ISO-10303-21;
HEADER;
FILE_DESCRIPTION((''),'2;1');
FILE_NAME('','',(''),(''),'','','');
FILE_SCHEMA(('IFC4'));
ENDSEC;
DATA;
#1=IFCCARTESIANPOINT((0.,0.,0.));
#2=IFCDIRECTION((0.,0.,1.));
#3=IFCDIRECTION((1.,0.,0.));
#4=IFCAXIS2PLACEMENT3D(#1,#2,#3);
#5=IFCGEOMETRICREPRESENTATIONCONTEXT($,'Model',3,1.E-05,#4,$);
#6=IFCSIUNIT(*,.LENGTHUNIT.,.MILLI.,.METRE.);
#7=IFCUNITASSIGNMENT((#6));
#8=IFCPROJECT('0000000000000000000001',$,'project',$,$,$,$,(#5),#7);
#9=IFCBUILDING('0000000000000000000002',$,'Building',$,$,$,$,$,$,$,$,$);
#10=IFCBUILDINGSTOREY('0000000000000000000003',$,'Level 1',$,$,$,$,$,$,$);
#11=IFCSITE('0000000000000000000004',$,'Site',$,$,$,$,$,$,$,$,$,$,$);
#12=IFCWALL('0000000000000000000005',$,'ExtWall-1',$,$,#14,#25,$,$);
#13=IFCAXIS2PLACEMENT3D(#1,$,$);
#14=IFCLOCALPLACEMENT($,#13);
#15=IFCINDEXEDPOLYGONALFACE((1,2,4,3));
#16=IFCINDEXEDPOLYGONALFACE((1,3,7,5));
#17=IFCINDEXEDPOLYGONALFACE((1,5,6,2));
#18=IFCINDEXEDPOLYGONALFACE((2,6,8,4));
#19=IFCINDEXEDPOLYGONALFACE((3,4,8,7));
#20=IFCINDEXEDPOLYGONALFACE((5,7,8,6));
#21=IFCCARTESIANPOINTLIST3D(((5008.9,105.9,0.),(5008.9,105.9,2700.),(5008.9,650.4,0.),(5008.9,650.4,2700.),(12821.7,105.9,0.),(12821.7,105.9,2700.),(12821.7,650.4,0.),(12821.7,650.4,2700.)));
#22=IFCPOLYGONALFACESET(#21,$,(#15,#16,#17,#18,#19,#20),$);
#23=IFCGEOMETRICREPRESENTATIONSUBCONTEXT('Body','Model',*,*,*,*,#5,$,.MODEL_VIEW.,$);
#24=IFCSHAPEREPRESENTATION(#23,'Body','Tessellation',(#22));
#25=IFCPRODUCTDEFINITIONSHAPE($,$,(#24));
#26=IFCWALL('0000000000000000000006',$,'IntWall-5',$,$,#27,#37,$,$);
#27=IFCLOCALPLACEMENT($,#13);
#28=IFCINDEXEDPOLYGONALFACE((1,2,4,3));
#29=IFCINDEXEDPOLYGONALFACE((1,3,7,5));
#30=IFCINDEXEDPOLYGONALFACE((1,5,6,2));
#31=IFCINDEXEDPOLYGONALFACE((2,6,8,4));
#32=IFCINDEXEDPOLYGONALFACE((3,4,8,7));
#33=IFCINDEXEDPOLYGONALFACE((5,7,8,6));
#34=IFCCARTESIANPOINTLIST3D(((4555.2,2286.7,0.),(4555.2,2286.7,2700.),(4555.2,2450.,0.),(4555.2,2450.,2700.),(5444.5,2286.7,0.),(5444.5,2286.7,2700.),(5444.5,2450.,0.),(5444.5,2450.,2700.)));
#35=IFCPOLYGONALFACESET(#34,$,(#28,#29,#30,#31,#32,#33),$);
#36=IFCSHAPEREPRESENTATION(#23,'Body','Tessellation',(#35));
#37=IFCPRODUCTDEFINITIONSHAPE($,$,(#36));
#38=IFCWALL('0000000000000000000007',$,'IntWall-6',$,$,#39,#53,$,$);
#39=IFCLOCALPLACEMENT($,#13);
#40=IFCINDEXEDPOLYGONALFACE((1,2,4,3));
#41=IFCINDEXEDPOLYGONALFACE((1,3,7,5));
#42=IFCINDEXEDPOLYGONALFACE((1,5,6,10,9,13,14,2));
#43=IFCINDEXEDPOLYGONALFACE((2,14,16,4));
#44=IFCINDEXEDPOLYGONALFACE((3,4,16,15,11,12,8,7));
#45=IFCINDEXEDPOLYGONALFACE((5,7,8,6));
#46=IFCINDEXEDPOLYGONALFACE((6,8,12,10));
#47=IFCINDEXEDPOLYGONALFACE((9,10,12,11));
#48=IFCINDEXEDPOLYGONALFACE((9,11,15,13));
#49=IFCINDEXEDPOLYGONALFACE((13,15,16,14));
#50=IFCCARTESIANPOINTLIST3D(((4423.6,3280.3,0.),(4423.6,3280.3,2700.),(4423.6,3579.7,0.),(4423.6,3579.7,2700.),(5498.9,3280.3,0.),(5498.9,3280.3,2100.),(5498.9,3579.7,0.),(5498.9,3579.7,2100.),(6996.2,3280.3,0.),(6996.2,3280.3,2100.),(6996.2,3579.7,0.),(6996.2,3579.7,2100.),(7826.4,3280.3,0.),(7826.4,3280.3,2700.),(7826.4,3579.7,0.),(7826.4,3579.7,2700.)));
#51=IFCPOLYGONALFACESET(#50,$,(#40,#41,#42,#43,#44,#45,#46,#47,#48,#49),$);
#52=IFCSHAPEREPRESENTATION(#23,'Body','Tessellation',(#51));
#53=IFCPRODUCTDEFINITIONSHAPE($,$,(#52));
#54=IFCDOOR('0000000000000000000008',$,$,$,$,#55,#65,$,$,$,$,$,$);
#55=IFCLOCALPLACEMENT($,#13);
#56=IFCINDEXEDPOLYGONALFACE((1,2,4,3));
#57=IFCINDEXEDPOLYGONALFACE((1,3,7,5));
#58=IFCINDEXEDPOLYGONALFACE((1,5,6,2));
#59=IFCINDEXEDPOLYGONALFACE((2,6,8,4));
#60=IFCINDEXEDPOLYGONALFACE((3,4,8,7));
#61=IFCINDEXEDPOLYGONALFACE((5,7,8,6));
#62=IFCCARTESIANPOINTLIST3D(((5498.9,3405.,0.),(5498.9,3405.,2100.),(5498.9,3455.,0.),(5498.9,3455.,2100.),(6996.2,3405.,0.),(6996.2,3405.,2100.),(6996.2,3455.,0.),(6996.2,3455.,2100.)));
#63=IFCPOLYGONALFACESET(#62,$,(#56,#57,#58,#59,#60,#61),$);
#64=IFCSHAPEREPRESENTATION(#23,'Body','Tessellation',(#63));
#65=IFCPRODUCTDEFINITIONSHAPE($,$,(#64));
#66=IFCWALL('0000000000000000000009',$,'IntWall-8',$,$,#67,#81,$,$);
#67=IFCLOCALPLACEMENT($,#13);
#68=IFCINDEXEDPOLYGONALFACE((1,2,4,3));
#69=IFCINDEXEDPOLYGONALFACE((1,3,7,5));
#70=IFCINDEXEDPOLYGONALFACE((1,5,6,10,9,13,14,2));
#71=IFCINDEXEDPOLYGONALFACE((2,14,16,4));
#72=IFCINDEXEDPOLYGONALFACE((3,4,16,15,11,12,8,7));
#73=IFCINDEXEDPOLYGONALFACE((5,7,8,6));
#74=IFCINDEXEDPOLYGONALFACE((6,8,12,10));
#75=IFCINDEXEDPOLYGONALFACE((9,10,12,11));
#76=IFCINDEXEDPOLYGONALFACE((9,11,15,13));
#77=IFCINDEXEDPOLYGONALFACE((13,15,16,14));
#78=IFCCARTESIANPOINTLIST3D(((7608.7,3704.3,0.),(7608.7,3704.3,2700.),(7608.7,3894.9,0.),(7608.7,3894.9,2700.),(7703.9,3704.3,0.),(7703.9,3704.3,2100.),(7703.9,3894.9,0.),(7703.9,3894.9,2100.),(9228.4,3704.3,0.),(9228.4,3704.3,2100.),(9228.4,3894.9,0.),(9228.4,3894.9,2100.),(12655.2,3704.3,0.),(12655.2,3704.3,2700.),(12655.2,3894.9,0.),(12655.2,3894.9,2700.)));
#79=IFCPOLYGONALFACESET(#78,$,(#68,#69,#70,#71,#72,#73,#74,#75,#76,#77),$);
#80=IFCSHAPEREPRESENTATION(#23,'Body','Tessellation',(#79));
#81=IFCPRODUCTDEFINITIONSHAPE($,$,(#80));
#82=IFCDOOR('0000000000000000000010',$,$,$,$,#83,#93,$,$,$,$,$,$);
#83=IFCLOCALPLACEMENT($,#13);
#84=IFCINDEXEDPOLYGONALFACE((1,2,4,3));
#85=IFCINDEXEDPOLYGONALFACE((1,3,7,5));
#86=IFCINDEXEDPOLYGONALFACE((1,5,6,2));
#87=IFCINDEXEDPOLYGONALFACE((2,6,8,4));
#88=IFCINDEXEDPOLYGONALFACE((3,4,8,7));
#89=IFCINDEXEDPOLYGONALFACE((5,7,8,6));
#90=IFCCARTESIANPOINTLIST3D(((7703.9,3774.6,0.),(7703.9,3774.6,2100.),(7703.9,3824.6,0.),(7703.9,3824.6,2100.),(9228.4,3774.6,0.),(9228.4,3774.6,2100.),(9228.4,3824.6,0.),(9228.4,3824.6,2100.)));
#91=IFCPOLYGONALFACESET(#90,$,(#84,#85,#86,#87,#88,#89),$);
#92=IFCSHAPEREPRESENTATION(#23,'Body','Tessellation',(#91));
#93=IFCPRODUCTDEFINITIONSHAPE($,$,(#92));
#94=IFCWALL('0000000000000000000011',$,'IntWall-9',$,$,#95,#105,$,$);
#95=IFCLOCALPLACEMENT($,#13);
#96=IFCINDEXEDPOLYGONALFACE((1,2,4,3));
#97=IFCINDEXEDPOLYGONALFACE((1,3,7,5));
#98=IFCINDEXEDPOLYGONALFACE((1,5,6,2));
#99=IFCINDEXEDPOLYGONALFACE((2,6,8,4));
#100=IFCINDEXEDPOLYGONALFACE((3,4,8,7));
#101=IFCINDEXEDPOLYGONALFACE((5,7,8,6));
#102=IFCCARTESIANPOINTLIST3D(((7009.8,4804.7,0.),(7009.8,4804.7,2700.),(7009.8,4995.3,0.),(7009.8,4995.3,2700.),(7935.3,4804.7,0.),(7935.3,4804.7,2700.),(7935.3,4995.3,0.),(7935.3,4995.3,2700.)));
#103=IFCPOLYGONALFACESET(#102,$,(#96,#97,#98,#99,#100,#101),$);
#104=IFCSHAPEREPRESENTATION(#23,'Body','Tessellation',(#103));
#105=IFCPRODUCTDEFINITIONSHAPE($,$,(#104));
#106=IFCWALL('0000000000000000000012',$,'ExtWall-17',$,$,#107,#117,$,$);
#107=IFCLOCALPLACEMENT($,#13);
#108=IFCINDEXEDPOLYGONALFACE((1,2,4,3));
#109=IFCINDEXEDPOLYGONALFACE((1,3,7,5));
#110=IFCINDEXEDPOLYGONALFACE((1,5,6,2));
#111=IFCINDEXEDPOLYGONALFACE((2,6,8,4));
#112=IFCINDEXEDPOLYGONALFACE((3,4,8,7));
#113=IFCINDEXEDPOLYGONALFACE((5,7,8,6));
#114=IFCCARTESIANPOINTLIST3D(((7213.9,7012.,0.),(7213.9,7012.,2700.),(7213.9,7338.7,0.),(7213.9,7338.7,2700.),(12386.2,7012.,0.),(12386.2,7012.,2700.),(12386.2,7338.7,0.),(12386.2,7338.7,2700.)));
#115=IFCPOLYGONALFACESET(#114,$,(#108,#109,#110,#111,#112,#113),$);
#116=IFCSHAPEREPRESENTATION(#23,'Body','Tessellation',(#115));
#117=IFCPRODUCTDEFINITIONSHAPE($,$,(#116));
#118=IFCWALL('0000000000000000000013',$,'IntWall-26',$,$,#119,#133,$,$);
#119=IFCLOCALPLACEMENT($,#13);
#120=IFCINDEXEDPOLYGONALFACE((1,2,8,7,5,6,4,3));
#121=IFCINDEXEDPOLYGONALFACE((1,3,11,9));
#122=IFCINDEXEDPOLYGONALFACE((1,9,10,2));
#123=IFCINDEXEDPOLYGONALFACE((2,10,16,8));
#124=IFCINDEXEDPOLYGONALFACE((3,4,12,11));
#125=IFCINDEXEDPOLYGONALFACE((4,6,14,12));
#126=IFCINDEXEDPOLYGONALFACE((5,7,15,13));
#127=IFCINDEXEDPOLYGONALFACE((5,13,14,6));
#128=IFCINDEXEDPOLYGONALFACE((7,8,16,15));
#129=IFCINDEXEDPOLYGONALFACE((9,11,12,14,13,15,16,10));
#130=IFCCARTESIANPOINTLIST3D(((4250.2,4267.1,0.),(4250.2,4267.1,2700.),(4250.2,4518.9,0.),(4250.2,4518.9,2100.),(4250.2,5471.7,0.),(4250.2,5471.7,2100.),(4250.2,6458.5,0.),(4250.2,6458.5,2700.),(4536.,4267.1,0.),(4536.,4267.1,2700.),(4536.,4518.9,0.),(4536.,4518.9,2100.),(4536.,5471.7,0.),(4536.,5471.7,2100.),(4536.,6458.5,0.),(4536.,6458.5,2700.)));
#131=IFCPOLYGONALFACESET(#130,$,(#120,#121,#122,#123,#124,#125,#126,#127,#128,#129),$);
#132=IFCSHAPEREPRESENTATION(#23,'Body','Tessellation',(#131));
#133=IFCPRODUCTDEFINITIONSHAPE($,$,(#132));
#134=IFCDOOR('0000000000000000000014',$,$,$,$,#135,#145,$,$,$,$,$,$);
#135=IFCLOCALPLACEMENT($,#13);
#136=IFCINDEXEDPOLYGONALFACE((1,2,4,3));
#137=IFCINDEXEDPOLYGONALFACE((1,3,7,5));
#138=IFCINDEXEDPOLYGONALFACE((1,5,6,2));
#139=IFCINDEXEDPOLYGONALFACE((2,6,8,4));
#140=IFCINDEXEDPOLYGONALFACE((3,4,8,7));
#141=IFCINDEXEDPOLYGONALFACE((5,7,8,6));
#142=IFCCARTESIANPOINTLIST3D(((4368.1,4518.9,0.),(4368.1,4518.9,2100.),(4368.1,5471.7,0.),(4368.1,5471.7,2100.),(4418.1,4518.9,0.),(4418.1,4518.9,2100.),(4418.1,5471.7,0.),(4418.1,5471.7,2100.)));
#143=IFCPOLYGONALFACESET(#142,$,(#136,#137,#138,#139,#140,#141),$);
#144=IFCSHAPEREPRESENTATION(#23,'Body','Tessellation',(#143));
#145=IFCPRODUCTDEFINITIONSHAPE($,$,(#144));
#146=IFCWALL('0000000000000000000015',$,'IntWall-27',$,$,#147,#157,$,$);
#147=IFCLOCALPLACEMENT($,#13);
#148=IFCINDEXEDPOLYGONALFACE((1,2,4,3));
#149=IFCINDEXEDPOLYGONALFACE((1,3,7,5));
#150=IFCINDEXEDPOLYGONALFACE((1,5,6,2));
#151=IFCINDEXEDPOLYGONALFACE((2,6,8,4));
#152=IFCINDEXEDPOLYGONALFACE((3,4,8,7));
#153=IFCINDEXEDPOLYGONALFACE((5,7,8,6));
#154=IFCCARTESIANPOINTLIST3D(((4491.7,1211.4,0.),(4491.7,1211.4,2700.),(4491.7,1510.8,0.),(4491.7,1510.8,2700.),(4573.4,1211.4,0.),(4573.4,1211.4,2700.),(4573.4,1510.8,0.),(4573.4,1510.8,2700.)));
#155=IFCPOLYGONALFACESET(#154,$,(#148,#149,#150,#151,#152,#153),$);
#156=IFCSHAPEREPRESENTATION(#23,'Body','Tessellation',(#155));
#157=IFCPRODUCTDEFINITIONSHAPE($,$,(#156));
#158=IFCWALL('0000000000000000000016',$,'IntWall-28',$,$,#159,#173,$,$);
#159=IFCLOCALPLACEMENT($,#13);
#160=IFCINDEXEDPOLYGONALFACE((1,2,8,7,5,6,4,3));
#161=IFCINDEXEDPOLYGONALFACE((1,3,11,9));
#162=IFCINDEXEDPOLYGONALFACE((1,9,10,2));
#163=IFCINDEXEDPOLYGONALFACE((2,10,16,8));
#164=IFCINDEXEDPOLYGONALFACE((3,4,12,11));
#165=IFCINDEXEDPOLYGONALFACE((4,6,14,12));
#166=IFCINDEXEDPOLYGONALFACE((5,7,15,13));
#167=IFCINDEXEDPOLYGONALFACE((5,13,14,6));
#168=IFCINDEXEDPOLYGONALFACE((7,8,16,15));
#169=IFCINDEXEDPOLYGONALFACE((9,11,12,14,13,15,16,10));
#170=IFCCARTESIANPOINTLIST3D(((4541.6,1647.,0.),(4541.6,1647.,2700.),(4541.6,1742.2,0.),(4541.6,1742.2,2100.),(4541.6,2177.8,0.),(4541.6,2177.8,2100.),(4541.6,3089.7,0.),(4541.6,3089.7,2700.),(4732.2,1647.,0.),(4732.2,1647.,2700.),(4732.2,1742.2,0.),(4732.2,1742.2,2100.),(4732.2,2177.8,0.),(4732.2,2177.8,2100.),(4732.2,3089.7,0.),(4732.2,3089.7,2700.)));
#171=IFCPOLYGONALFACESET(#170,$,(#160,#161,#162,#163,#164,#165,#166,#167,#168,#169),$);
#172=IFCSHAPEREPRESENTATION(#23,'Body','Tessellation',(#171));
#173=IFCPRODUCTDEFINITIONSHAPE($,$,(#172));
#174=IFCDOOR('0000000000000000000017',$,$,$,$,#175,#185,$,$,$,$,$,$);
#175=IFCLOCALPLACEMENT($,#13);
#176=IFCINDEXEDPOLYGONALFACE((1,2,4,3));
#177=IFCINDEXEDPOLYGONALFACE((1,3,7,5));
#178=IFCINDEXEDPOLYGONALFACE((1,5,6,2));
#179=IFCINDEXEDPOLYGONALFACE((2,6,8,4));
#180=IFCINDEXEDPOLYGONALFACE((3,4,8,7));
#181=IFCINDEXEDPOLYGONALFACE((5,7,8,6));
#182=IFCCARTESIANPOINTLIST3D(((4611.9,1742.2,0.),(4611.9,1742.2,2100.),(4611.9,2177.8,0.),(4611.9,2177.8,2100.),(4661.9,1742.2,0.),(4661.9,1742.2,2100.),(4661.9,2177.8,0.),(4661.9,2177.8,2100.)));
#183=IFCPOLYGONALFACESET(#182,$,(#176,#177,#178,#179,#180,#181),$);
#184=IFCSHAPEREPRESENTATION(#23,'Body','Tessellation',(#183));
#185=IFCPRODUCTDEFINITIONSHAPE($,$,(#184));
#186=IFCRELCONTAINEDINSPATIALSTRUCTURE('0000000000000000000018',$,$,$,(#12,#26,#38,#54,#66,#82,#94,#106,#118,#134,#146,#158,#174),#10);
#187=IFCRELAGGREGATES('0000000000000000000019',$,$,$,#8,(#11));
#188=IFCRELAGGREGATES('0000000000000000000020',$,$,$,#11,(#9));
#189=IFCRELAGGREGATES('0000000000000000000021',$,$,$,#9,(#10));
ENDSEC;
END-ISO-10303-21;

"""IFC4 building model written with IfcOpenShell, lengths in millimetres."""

from ifc_helpers import new_model, si_unit, frame, origin_with_axes, place, context, subcontext, project, spatial, indexed_curve, outline, extrude, element, fill, save


model = new_model("IFC4")

# Units and contexts
model_context = context("Model", 3, precision=1e-05, world=origin_with_axes())
body_context = subcontext(model_context, "Body", "Model", "MODEL_VIEW")
ifc_project = project(units=[si_unit("LENGTHUNIT", "METRE", prefix="MILLI")], contexts=[model_context])

# Site, building, storey
site = spatial("IfcSite", under=ifc_project, Name="Site")
building = spatial("IfcBuilding", under=site, Name="Building")
storey = spatial("IfcBuildingStorey", under=building, Name="Level 1")

# Walls
wall_1_placement = place(None, frame((5008.9, 378.1, 0.0), z_axis=(0.0, 0.0, 1.0), x_axis=(1.0, 0.0, 0.0)))
element("IfcWall", 1, at=wall_1_placement, inside=storey, Name="ExtWall-1", context=body_context, shape_type="SweptSolid", body=[
    extrude(outline(indexed_curve([(0.0, 0.0), (0.0, 544.4), (7812.8, 544.4), (7812.8, 0.0), (0.0, 0.0)], self_intersect=False)), frame((0.0, -272.2, 0.0), z_axis=(0.0, 0.0, 1.0), x_axis=(1.0, 0.0, 0.0)), (0.0, 0.0, 1.0), 2700.0),
])
wall_2_placement = place(None, frame((4555.2, 2368.3, 0.0), z_axis=(0.0, 0.0, 1.0), x_axis=(1.0, 0.0, 0.0)))
element("IfcWall", 2, at=wall_2_placement, inside=storey, Name="IntWall-5", context=body_context, shape_type="SweptSolid", body=[
    extrude(outline(indexed_curve([(0.0, 0.0), (0.0, 163.3), (889.3, 163.3), (889.3, 0.0), (0.0, 0.0)], self_intersect=False)), frame((0.0, -81.7, 0.0), z_axis=(0.0, 0.0, 1.0), x_axis=(1.0, 0.0, 0.0)), (0.0, 0.0, 1.0), 2700.0),
])

# Walls, openings, doors
wall_3_placement = place(None, frame((4423.6, 3430.0, 0.0), z_axis=(0.0, 0.0, 1.0), x_axis=(1.0, 0.0, 0.0)))
wall_3 = element("IfcWall", 3, at=wall_3_placement, inside=storey, Name="IntWall-6", context=body_context, shape_type="SweptSolid", body=[
    extrude(outline(indexed_curve([(0.0, 0.0), (0.0, 299.4), (3402.8, 299.4), (3402.8, 0.0), (0.0, 0.0)], self_intersect=False)), frame((0.0, -149.7, 0.0), z_axis=(0.0, 0.0, 1.0), x_axis=(1.0, 0.0, 0.0)), (0.0, 0.0, 1.0), 2700.0),
])
opening_1_placement = place(wall_3_placement, frame((1075.3, 0.0, 0.0), z_axis=(0.0, 0.0, 1.0), x_axis=(1.0, 0.0, 0.0)))
opening_1 = element("IfcOpeningElement", 4, at=opening_1_placement, cuts=wall_3, context=body_context, shape_type="SweptSolid", body=[
    extrude(outline(indexed_curve([(0.0, 0.0), (0.0, 399.4), (1497.2, 399.4), (1497.2, 0.0), (0.0, 0.0)], self_intersect=False)), frame((0.0, -199.7, 0.0), z_axis=(0.0, 0.0, 1.0), x_axis=(1.0, 0.0, 0.0)), (0.0, 0.0, 1.0), 2100.0),
])
door_1_placement = place(opening_1_placement, origin_with_axes())
door_1 = element("IfcDoor", 5, at=door_1_placement, inside=storey, context=body_context, shape_type="SweptSolid", body=[
    extrude(outline(indexed_curve([(0.0, 0.0), (0.0, 50.0), (1497.2, 50.0), (1497.2, 0.0), (0.0, 0.0)], self_intersect=False)), frame((0.0, -25.0, 0.0), z_axis=(0.0, 0.0, 1.0), x_axis=(1.0, 0.0, 0.0)), (0.0, 0.0, 1.0), 2100.0),
])
fill(opening_1, door_1)
wall_4_placement = place(None, frame((7608.7, 3799.6, 0.0), z_axis=(0.0, 0.0, 1.0), x_axis=(1.0, 0.0, 0.0)))
wall_4 = element("IfcWall", 6, at=wall_4_placement, inside=storey, Name="IntWall-8", context=body_context, shape_type="SweptSolid", body=[
    extrude(outline(indexed_curve([(0.0, 0.0), (0.0, 190.6), (5046.5, 190.6), (5046.5, 0.0), (0.0, 0.0)], self_intersect=False)), frame((0.0, -95.3, 0.0), z_axis=(0.0, 0.0, 1.0), x_axis=(1.0, 0.0, 0.0)), (0.0, 0.0, 1.0), 2700.0),
])
opening_2_placement = place(wall_4_placement, frame((95.3, 0.0, 0.0), z_axis=(0.0, 0.0, 1.0), x_axis=(1.0, 0.0, 0.0)))
opening_2 = element("IfcOpeningElement", 7, at=opening_2_placement, cuts=wall_4, context=body_context, shape_type="SweptSolid", body=[
    extrude(outline(indexed_curve([(0.0, 0.0), (0.0, 290.6), (1524.5, 290.6), (1524.5, 0.0), (0.0, 0.0)], self_intersect=False)), frame((0.0, -145.3, 0.0), z_axis=(0.0, 0.0, 1.0), x_axis=(1.0, 0.0, 0.0)), (0.0, 0.0, 1.0), 2100.0),
])
door_2_placement = place(opening_2_placement, origin_with_axes())
door_2 = element("IfcDoor", 8, at=door_2_placement, inside=storey, context=body_context, shape_type="SweptSolid", body=[
    extrude(outline(indexed_curve([(0.0, 0.0), (0.0, 50.0), (1524.5, 50.0), (1524.5, 0.0), (0.0, 0.0)], self_intersect=False)), frame((0.0, -25.0, 0.0), z_axis=(0.0, 0.0, 1.0), x_axis=(1.0, 0.0, 0.0)), (0.0, 0.0, 1.0), 2100.0),
])
fill(opening_2, door_2)

# Walls
wall_5_placement = place(None, frame((7009.8, 4900.0, 0.0), z_axis=(0.0, 0.0, 1.0), x_axis=(1.0, 0.0, 0.0)))
element("IfcWall", 9, at=wall_5_placement, inside=storey, Name="IntWall-9", context=body_context, shape_type="SweptSolid", body=[
    extrude(outline(indexed_curve([(0.0, 0.0), (0.0, 190.6), (925.6, 190.6), (925.6, 0.0), (0.0, 0.0)], self_intersect=False)), frame((0.0, -95.3, 0.0), z_axis=(0.0, 0.0, 1.0), x_axis=(1.0, 0.0, 0.0)), (0.0, 0.0, 1.0), 2700.0),
])
wall_6_placement = place(None, frame((7213.9, 7175.3, 0.0), z_axis=(0.0, 0.0, 1.0), x_axis=(1.0, 0.0, 0.0)))
element("IfcWall", 10, at=wall_6_placement, inside=storey, Name="ExtWall-17", context=body_context, shape_type="SweptSolid", body=[
    extrude(outline(indexed_curve([(0.0, 0.0), (0.0, 326.7), (5172.3, 326.7), (5172.3, 0.0), (0.0, 0.0)], self_intersect=False)), frame((0.0, -163.3, 0.0), z_axis=(0.0, 0.0, 1.0), x_axis=(1.0, 0.0, 0.0)), (0.0, 0.0, 1.0), 2700.0),
])

# Wall, opening, door
wall_7_placement = place(None, frame((4393.1, 4267.1, 0.0), z_axis=(0.0, 0.0, 1.0), x_axis=(0.0, 1.0, 0.0)))
wall_7 = element("IfcWall", 11, at=wall_7_placement, inside=storey, Name="IntWall-26", context=body_context, shape_type="SweptSolid", body=[
    extrude(outline(indexed_curve([(0.0, 0.0), (0.0, 285.8), (2191.4, 285.8), (2191.4, 0.0), (0.0, 0.0)], self_intersect=False)), frame((0.0, -142.9, 0.0), z_axis=(0.0, 0.0, 1.0), x_axis=(1.0, 0.0, 0.0)), (0.0, 0.0, 1.0), 2700.0),
])
opening_3_placement = place(wall_7_placement, frame((251.8, 0.0, 0.0), z_axis=(0.0, 0.0, 1.0), x_axis=(1.0, 0.0, 0.0)))
opening_3 = element("IfcOpeningElement", 12, at=opening_3_placement, cuts=wall_7, context=body_context, shape_type="SweptSolid", body=[
    extrude(outline(indexed_curve([(0.0, 0.0), (0.0, 385.8), (952.8, 385.8), (952.8, 0.0), (0.0, 0.0)], self_intersect=False)), frame((0.0, -192.9, 0.0), z_axis=(0.0, 0.0, 1.0), x_axis=(1.0, 0.0, 0.0)), (0.0, 0.0, 1.0), 2100.0),
])
door_3_placement = place(opening_3_placement, origin_with_axes())
door_3 = element("IfcDoor", 13, at=door_3_placement, inside=storey, context=body_context, shape_type="SweptSolid", body=[
    extrude(outline(indexed_curve([(0.0, 0.0), (0.0, 50.0), (952.8, 50.0), (952.8, 0.0), (0.0, 0.0)], self_intersect=False)), frame((0.0, -25.0, 0.0), z_axis=(0.0, 0.0, 1.0), x_axis=(1.0, 0.0, 0.0)), (0.0, 0.0, 1.0), 2100.0),
])
fill(opening_3, door_3)

# Wall
wall_8_placement = place(None, frame((4532.5, 1211.4, 0.0), z_axis=(0.0, 0.0, 1.0), x_axis=(0.0, 1.0, 0.0)))
element("IfcWall", 14, at=wall_8_placement, inside=storey, Name="IntWall-27", context=body_context, shape_type="SweptSolid", body=[
    extrude(outline(indexed_curve([(0.0, 0.0), (0.0, 81.7), (299.4, 81.7), (299.4, 0.0), (0.0, 0.0)], self_intersect=False)), frame((0.0, -40.8, 0.0), z_axis=(0.0, 0.0, 1.0), x_axis=(1.0, 0.0, 0.0)), (0.0, 0.0, 1.0), 2700.0),
])

# Wall, opening, door
wall_9_placement = place(None, frame((4636.9, 1647.0, 0.0), z_axis=(0.0, 0.0, 1.0), x_axis=(0.0, 1.0, 0.0)))
wall_9 = element("IfcWall", 15, at=wall_9_placement, inside=storey, Name="IntWall-28", context=body_context, shape_type="SweptSolid", body=[
    extrude(outline(indexed_curve([(0.0, 0.0), (0.0, 190.6), (1442.8, 190.6), (1442.8, 0.0), (0.0, 0.0)], self_intersect=False)), frame((0.0, -95.3, 0.0), z_axis=(0.0, 0.0, 1.0), x_axis=(1.0, 0.0, 0.0)), (0.0, 0.0, 1.0), 2700.0),
])
opening_4_placement = place(wall_9_placement, frame((95.3, 0.0, 0.0), z_axis=(0.0, 0.0, 1.0), x_axis=(1.0, 0.0, 0.0)))
opening_4 = element("IfcOpeningElement", 16, at=opening_4_placement, cuts=wall_9, context=body_context, shape_type="SweptSolid", body=[
    extrude(outline(indexed_curve([(0.0, 0.0), (0.0, 290.6), (435.6, 290.6), (435.6, 0.0), (0.0, 0.0)], self_intersect=False)), frame((0.0, -145.3, 0.0), z_axis=(0.0, 0.0, 1.0), x_axis=(1.0, 0.0, 0.0)), (0.0, 0.0, 1.0), 2100.0),
])
door_4_placement = place(opening_4_placement, origin_with_axes())
door_4 = element("IfcDoor", 17, at=door_4_placement, inside=storey, context=body_context, shape_type="SweptSolid", body=[
    extrude(outline(indexed_curve([(0.0, 0.0), (0.0, 50.0), (435.6, 50.0), (435.6, 0.0), (0.0, 0.0)], self_intersect=False)), frame((0.0, -25.0, 0.0), z_axis=(0.0, 0.0, 1.0), x_axis=(1.0, 0.0, 0.0)), (0.0, 0.0, 1.0), 2100.0),
])
fill(opening_4, door_4)

save(model, "model.ifc")
